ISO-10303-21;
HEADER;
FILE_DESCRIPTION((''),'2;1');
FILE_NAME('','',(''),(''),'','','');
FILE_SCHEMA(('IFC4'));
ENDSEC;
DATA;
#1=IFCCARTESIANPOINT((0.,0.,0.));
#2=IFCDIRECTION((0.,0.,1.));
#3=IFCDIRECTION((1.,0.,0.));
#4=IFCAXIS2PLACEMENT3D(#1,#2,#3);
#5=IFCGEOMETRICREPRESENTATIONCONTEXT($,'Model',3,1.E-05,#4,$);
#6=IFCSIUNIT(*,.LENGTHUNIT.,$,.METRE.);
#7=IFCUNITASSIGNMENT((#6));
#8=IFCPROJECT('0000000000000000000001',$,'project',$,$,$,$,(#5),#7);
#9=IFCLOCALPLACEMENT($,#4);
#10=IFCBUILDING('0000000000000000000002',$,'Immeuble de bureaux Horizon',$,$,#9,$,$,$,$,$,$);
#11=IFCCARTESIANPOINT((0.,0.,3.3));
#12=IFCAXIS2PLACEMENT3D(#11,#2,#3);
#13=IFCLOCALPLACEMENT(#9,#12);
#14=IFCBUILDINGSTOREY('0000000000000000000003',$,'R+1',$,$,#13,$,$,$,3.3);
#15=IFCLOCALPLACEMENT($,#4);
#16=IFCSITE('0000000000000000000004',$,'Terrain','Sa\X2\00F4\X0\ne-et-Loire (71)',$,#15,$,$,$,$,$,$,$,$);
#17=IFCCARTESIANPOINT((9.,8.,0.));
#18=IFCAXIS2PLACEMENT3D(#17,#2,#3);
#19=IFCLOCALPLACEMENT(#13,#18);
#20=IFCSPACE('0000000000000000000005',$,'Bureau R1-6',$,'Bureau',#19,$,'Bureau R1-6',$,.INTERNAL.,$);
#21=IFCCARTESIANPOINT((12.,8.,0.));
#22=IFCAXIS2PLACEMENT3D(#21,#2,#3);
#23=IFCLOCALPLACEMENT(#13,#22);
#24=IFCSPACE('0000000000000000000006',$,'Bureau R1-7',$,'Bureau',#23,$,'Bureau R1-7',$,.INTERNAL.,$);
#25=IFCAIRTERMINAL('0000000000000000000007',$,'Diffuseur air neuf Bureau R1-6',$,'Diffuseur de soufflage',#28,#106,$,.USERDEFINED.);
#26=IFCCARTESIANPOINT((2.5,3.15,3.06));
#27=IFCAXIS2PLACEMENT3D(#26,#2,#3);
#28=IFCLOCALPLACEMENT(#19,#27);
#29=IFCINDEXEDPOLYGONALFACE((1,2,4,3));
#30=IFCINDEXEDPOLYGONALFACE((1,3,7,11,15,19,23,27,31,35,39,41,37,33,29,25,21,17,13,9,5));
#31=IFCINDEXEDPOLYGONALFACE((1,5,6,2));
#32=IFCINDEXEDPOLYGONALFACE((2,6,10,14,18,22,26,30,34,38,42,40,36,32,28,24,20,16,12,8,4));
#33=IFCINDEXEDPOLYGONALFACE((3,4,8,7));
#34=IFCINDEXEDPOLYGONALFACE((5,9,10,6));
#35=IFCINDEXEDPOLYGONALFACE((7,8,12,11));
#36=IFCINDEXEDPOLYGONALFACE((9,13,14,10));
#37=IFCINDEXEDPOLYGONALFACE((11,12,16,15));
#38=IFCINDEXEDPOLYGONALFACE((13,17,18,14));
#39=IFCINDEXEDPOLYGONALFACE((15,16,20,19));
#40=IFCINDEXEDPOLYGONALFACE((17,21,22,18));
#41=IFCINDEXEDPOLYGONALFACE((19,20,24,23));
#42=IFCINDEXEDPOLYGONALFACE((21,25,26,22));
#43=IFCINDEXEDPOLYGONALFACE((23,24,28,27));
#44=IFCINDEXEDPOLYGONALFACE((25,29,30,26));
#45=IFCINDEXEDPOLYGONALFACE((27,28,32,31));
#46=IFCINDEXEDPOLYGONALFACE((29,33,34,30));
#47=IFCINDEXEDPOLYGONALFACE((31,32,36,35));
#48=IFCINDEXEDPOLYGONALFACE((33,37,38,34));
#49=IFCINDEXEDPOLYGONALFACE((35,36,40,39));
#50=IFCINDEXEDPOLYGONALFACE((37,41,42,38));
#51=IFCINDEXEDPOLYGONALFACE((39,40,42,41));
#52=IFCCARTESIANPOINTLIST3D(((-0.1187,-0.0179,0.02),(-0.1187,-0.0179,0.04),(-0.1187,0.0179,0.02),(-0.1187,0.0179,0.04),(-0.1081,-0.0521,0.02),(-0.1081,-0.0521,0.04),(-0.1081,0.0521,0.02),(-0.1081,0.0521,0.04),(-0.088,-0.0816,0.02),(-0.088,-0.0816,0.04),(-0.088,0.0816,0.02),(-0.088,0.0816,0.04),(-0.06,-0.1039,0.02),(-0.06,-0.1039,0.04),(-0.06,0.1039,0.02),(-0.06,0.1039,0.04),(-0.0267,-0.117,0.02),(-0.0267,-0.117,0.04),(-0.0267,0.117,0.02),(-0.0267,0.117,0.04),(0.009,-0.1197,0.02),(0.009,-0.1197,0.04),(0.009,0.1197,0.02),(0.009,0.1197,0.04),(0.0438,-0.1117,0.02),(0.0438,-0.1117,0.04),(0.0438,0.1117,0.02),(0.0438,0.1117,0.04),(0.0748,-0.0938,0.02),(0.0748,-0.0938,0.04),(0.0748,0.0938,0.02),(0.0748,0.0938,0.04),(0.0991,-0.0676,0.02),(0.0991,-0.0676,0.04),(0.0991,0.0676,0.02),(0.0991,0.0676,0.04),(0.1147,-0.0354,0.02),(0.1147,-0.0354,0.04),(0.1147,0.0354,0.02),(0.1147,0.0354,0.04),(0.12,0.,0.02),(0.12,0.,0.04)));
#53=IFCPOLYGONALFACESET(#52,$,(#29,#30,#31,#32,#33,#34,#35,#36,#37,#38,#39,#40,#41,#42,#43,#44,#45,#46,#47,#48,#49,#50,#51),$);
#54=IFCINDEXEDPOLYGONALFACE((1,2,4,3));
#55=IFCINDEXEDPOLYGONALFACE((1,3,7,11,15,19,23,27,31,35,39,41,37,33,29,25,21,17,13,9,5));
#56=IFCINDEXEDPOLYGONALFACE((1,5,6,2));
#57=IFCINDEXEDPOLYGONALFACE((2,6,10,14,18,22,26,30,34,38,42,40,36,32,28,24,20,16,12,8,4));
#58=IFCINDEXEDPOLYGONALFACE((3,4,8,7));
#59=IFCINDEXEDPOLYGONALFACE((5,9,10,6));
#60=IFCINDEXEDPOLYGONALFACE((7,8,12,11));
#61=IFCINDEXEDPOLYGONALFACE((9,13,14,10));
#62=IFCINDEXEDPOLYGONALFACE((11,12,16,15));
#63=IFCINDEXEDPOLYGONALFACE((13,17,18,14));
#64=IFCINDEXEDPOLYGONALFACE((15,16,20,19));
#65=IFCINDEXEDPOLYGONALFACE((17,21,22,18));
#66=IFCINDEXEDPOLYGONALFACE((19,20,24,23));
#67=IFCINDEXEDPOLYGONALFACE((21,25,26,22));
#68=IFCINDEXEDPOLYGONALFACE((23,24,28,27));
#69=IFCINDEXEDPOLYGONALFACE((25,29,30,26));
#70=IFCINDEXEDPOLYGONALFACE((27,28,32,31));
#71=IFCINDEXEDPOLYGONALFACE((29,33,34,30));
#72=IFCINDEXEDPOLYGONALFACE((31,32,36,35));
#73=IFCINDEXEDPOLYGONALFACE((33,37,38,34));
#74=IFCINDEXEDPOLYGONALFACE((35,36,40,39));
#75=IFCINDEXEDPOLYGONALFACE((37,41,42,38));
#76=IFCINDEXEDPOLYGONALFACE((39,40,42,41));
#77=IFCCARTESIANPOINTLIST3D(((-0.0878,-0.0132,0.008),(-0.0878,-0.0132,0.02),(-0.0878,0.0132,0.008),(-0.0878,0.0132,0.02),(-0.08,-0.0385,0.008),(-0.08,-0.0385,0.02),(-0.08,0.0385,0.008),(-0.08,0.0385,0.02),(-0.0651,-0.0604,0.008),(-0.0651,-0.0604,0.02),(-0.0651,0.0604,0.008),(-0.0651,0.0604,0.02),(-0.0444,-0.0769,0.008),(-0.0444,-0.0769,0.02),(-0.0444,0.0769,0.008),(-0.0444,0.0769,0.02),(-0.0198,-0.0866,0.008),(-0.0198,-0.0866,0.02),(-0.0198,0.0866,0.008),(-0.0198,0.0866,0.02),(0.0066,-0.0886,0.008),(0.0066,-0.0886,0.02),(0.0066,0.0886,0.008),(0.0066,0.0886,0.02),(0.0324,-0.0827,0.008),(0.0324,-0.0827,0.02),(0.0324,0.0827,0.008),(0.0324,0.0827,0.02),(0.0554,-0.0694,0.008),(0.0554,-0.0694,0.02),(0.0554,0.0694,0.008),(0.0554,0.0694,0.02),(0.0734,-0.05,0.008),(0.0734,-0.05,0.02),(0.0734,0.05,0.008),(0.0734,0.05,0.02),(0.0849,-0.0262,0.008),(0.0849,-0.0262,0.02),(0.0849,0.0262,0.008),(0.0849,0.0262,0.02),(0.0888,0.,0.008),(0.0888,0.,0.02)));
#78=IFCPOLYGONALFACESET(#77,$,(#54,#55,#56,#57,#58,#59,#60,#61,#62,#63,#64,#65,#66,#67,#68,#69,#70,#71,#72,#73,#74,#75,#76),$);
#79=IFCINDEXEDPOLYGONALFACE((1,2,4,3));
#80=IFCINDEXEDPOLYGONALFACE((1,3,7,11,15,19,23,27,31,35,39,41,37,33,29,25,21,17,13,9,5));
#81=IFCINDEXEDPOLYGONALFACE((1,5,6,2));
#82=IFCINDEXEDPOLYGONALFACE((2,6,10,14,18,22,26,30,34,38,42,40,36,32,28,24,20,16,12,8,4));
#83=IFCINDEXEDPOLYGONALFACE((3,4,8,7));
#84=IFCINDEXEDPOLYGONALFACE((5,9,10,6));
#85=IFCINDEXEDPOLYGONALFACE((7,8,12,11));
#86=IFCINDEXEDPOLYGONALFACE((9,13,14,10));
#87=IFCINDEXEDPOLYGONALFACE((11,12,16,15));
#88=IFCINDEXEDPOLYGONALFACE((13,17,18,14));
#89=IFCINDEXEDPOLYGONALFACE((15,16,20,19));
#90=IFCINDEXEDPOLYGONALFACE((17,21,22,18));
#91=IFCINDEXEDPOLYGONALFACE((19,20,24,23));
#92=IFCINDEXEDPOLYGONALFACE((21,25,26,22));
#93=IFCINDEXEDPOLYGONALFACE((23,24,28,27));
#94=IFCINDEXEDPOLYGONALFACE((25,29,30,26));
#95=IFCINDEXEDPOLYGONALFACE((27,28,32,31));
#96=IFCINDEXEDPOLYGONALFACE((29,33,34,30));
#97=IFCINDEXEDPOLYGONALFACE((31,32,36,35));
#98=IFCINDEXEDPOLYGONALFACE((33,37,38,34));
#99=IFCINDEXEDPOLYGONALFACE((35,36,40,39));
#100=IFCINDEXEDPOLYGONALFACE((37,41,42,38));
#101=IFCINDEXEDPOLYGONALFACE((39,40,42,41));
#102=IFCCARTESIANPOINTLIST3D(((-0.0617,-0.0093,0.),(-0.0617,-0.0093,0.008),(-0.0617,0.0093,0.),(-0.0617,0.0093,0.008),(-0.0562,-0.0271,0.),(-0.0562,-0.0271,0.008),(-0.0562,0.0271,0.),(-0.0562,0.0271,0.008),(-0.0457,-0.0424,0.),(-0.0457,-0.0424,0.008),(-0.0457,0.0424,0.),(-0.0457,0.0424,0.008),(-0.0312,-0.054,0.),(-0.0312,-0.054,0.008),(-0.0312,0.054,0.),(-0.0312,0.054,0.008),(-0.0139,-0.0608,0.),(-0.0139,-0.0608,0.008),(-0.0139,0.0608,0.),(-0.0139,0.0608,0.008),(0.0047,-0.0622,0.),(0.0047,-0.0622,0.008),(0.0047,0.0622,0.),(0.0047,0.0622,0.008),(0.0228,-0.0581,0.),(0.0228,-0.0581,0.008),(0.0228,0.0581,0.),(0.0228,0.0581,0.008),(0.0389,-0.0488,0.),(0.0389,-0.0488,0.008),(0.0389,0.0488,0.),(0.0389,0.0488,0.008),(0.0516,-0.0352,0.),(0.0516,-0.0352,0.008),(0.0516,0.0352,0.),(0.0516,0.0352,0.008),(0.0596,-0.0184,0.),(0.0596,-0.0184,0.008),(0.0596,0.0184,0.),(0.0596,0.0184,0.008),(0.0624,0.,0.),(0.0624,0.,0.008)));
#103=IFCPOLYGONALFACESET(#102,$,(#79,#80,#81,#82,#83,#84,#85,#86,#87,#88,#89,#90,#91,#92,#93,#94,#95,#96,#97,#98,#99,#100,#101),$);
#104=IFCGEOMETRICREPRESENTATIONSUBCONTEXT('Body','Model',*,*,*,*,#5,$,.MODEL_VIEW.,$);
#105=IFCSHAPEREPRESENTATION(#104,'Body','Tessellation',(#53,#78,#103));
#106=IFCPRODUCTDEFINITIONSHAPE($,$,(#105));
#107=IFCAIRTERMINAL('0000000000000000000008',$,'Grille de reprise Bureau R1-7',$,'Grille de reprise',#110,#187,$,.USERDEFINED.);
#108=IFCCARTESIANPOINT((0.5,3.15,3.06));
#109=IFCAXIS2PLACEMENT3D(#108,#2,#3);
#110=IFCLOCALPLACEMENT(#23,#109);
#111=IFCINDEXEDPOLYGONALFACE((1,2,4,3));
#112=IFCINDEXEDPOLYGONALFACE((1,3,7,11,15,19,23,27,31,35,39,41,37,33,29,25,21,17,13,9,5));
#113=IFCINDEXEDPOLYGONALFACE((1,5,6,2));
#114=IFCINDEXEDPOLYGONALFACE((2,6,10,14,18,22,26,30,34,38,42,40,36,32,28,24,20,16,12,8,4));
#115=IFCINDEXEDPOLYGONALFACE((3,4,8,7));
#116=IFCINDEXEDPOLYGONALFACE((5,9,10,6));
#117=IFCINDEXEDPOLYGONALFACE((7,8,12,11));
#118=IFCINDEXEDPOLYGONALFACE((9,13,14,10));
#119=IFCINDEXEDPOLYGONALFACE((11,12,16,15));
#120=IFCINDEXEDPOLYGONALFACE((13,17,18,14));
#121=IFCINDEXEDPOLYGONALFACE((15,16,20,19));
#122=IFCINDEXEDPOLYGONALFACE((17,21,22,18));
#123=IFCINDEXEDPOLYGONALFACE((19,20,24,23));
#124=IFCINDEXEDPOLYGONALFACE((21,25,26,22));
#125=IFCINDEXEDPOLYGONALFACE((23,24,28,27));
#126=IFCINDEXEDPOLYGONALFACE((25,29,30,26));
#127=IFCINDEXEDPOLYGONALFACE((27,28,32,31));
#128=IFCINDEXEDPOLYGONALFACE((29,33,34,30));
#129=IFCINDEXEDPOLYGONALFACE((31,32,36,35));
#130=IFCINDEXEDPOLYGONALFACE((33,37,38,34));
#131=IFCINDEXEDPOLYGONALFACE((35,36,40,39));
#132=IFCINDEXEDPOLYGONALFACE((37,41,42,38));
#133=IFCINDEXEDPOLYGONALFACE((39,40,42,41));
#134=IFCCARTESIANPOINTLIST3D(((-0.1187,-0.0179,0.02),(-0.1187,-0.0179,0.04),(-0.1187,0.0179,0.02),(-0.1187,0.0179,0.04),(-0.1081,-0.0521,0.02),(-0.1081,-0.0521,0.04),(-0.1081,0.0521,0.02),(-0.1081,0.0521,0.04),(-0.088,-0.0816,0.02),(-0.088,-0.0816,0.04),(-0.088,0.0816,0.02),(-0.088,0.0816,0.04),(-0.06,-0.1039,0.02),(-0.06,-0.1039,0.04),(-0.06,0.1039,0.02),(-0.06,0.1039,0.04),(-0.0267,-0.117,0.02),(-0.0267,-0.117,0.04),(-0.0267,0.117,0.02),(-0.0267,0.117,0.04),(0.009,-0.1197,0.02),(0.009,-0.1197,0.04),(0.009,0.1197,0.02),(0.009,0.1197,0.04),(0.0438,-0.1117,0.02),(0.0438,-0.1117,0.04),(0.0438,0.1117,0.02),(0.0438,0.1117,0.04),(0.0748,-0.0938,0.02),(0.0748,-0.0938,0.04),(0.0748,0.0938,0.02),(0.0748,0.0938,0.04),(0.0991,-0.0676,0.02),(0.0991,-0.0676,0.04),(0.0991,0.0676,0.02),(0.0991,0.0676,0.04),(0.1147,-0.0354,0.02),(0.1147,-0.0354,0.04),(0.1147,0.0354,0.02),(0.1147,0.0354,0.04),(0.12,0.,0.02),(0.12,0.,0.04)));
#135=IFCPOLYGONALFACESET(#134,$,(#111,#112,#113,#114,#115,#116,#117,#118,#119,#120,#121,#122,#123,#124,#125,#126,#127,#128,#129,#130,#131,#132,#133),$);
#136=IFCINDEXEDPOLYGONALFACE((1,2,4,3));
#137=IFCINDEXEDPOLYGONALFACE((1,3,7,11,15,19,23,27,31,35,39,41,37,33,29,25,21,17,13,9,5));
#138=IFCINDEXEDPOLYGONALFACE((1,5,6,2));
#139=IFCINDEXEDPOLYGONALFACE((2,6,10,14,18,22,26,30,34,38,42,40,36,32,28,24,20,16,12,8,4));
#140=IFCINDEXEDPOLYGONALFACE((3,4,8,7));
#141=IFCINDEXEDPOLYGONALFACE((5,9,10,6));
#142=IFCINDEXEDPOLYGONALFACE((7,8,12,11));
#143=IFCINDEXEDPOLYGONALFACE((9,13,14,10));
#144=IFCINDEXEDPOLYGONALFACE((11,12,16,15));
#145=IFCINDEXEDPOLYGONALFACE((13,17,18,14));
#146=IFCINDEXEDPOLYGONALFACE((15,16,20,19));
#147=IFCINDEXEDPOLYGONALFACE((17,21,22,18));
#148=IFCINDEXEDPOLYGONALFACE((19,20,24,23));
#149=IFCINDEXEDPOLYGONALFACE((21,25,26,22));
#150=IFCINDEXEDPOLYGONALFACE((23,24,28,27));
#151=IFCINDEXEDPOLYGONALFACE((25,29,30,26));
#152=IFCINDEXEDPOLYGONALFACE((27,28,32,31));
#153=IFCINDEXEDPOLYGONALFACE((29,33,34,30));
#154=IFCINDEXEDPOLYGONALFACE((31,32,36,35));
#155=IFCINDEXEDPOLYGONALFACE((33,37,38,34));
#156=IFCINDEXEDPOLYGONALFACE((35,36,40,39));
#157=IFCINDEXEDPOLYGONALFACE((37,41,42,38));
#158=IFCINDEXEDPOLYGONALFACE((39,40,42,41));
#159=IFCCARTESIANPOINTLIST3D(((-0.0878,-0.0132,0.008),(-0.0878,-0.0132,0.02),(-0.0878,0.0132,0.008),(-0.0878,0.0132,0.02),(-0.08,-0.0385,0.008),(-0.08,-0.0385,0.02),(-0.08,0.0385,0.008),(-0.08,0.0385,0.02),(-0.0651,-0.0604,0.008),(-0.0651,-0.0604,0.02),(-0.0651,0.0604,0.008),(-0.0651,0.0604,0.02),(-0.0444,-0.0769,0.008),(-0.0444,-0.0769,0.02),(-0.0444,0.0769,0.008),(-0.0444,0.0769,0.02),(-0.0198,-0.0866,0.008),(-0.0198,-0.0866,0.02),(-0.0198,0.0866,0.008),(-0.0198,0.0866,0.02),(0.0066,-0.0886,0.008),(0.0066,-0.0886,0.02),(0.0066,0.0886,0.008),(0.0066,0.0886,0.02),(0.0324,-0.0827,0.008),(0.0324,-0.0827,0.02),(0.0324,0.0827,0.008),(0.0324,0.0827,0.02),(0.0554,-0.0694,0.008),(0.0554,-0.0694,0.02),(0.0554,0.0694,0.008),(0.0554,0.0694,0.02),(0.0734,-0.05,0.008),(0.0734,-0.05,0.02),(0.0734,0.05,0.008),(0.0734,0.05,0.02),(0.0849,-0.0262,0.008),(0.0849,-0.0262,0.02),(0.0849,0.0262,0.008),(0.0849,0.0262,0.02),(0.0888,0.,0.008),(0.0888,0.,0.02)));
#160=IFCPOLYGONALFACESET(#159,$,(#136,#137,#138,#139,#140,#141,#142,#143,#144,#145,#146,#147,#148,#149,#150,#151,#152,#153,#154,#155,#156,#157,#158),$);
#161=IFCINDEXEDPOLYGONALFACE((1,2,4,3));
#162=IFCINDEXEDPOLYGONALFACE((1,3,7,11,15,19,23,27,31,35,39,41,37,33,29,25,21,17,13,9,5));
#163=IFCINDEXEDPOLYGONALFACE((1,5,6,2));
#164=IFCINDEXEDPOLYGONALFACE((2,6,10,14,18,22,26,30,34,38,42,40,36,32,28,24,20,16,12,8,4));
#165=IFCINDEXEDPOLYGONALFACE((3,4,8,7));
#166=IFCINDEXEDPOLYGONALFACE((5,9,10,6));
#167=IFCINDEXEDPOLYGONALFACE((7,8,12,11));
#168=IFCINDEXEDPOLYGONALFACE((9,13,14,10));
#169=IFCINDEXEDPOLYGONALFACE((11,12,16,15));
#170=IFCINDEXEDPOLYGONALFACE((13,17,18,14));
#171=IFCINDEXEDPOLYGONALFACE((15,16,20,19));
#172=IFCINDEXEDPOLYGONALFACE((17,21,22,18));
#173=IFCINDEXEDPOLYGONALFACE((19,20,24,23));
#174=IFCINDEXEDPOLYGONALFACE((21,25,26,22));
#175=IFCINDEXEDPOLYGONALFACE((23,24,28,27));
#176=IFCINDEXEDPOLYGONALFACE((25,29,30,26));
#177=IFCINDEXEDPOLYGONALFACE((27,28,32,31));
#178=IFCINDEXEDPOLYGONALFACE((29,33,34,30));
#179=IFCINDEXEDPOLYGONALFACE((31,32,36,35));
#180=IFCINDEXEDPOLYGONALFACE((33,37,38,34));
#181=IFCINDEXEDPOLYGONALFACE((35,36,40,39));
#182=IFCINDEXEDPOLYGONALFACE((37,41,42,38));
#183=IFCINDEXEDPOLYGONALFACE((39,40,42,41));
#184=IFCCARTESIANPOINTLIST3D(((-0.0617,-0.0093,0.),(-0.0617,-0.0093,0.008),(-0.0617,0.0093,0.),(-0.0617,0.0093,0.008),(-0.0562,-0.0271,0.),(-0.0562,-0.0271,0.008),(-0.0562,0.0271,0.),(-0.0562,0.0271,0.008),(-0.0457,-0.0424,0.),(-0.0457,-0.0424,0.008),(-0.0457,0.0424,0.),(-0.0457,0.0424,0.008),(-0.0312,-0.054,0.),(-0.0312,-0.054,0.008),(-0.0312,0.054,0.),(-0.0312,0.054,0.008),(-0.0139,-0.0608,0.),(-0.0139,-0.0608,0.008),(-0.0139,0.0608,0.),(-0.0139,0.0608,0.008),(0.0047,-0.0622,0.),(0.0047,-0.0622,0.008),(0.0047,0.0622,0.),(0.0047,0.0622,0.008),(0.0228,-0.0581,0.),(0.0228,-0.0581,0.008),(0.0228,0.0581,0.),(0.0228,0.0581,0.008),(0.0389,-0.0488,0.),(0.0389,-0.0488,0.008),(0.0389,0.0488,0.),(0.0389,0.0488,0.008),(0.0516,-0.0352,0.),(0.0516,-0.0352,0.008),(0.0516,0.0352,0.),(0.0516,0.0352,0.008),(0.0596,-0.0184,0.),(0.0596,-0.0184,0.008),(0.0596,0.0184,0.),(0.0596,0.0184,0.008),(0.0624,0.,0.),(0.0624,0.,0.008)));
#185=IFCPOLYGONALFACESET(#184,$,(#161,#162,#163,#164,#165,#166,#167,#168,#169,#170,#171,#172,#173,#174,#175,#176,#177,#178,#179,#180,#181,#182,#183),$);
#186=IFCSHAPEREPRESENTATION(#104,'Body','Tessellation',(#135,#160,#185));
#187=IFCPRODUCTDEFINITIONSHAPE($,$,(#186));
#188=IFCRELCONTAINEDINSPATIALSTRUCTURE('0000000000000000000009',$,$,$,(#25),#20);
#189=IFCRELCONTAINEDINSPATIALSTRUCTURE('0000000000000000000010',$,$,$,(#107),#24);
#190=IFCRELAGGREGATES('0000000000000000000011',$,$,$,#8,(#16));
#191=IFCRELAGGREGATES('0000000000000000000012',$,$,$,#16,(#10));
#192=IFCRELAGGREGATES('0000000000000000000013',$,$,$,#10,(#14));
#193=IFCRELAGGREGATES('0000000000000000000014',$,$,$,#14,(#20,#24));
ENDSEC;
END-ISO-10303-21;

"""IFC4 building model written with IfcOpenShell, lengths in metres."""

from ifc_helpers import new_model, si_unit, frame, origin_with_axes, place, context, subcontext, project, spatial, circle, extrude, element, save


model = new_model("IFC4")

# Units and contexts
model_context = context("Model", 3, precision=1e-05, world=origin_with_axes())
body_context = subcontext(model_context, "Body", "Model", "MODEL_VIEW")
ifc_project = project(units=[si_unit("LENGTHUNIT", "METRE")], contexts=[model_context])

# Site, building, storey
site_placement = place(None, origin_with_axes())
site = spatial("IfcSite", under=ifc_project, at=site_placement, Name="Terrain", Description="Saône-et-Loire (71)")
building_placement = place(None, origin_with_axes())
building = spatial("IfcBuilding", under=site, at=building_placement, Name="Immeuble de bureaux Horizon")
storey_placement = place(building_placement, frame((0.0, 0.0, 3.3), z_axis=(0.0, 0.0, 1.0), x_axis=(1.0, 0.0, 0.0)))
storey = spatial("IfcBuildingStorey", under=building, at=storey_placement, Name="R+1", Elevation=3.3)

# Shared definitions
space_1_placement = place(storey_placement, frame((9.0, 8.0, 0.0), z_axis=(0.0, 0.0, 1.0), x_axis=(1.0, 0.0, 0.0)))
space_1 = spatial("IfcSpace", under=storey, at=space_1_placement, Name="Bureau R1-6", ObjectType="Bureau", LongName="Bureau R1-6", PredefinedType="INTERNAL")

# Air terminal
air_terminal_1_placement = place(space_1_placement, frame((2.5, 3.15, 3.06), z_axis=(0.0, 0.0, 1.0), x_axis=(1.0, 0.0, 0.0)))
element("IfcAirTerminal", 1, at=air_terminal_1_placement, inside=space_1, Name="Diffuseur air neuf Bureau R1-6", ObjectType="Diffuseur de soufflage", PredefinedType="USERDEFINED", context=body_context, shape_type="SweptSolid", body=[
    extrude(circle(Radius=0.12), frame((0.0, 0.0, 0.02), z_axis=(0.0, 0.0, 1.0), x_axis=(1.0, 0.0, 0.0)), (0.0, 0.0, 1.0), 0.02),
    extrude(circle(Radius=0.0888), frame((0.0, 0.0, 0.008), z_axis=(0.0, 0.0, 1.0), x_axis=(1.0, 0.0, 0.0)), (0.0, 0.0, 1.0), 0.012),
    extrude(circle(Radius=0.0624), origin_with_axes(), (0.0, 0.0, 1.0), 0.008),
])

# Shared definitions
space_2_placement = place(storey_placement, frame((12.0, 8.0, 0.0), z_axis=(0.0, 0.0, 1.0), x_axis=(1.0, 0.0, 0.0)))
space_2 = spatial("IfcSpace", under=storey, at=space_2_placement, Name="Bureau R1-7", ObjectType="Bureau", LongName="Bureau R1-7", PredefinedType="INTERNAL")

# Air terminal
air_terminal_2_placement = place(space_2_placement, frame((0.5, 3.15, 3.06), z_axis=(0.0, 0.0, 1.0), x_axis=(1.0, 0.0, 0.0)))
element("IfcAirTerminal", 2, at=air_terminal_2_placement, inside=space_2, Name="Grille de reprise Bureau R1-7", ObjectType="Grille de reprise", PredefinedType="USERDEFINED", context=body_context, shape_type="SweptSolid", body=[
    extrude(circle(Radius=0.12), frame((0.0, 0.0, 0.02), z_axis=(0.0, 0.0, 1.0), x_axis=(1.0, 0.0, 0.0)), (0.0, 0.0, 1.0), 0.02),
    extrude(circle(Radius=0.0888), frame((0.0, 0.0, 0.008), z_axis=(0.0, 0.0, 1.0), x_axis=(1.0, 0.0, 0.0)), (0.0, 0.0, 1.0), 0.012),
    extrude(circle(Radius=0.0624), origin_with_axes(), (0.0, 0.0, 1.0), 0.008),
])

save(model, "model.ifc")
